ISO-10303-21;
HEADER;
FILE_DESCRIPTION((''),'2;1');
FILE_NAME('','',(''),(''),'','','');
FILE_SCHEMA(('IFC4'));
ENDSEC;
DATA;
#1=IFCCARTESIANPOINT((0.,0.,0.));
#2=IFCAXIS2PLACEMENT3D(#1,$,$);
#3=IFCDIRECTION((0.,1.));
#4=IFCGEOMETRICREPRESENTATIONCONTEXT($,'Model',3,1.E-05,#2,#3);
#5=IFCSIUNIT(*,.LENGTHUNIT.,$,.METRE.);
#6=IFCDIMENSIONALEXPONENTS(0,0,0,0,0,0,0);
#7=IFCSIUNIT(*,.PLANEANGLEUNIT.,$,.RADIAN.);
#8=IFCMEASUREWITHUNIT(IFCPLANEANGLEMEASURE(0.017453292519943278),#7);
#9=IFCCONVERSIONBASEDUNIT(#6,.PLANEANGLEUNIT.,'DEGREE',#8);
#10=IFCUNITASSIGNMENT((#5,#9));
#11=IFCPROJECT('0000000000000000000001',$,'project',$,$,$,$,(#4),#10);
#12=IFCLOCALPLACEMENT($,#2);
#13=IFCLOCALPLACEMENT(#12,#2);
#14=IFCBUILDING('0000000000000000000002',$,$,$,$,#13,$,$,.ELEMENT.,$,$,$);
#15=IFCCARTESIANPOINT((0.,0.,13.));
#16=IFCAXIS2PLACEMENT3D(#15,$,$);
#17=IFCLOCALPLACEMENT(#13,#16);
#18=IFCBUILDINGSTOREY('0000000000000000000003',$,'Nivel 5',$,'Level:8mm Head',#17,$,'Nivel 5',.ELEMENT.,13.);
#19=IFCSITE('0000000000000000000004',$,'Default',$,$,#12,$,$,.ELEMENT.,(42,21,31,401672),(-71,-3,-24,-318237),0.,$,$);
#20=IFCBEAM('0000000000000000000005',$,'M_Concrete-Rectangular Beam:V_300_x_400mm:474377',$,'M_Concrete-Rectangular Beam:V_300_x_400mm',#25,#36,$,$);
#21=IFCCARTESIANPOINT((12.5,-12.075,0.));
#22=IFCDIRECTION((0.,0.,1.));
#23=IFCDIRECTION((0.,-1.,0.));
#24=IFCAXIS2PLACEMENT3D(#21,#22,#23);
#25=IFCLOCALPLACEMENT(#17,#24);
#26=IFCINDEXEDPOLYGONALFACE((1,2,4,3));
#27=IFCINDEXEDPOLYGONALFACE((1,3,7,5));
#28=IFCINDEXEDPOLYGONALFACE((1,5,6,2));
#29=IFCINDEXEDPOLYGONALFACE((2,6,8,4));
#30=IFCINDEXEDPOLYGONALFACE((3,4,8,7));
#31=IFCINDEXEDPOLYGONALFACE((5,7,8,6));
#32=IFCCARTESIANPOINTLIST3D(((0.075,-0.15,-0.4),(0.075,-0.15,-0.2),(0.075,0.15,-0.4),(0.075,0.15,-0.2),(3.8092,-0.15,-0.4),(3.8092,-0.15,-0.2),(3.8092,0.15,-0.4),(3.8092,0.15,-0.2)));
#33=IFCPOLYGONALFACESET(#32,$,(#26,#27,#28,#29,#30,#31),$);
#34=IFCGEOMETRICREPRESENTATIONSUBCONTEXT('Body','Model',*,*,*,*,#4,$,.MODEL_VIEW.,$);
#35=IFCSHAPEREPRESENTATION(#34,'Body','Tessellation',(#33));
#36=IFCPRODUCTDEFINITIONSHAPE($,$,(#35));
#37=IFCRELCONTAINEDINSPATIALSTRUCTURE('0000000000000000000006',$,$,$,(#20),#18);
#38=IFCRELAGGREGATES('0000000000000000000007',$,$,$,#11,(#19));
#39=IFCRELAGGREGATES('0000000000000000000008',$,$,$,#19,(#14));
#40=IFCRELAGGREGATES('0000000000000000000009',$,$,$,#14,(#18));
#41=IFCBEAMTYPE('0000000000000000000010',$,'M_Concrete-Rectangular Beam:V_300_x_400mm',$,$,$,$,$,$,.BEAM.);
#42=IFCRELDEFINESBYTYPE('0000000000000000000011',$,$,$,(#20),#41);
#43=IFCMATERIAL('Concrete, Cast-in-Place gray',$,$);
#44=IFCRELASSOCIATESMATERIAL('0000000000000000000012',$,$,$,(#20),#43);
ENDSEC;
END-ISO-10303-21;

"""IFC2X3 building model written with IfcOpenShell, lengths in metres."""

from ifc_helpers import new_model, entity, si_unit, converted_unit, direction, frame, frame_2d, origin, place, context, subcontext, project, spatial, rectangle, extrude, material, type_object, element, save


model = new_model("IFC2X3")

# Units and contexts
model_context = context("Model", 3, precision=1e-05, world=origin(), true_north=direction((0.0, 1.0)))
body_context = subcontext(model_context, "Body", "Model", "MODEL_VIEW")
ifc_project = project(units=[si_unit("LENGTHUNIT", "METRE"), converted_unit("PLANEANGLEUNIT", "DEGREE", entity("IfcPlaneAngleMeasure", 0.017453292519943278), si_unit("PLANEANGLEUNIT", "RADIAN"), dimensions=[0, 0, 0, 0, 0, 0, 0])], contexts=[model_context])

# Site, building, storey
site_placement = place(None, origin())
site = spatial("IfcSite", under=ifc_project, at=site_placement, Name="Default", CompositionType="ELEMENT", RefLatitude=(42, 21, 31, 401672), RefLongitude=(-71, -3, -24, -318237), RefElevation=0.0)
building_placement = place(site_placement, origin())
building = spatial("IfcBuilding", under=site, at=building_placement, CompositionType="ELEMENT")
storey_placement = place(building_placement, frame((0.0, 0.0, 13.0)))
storey = spatial("IfcBuildingStorey", under=building, at=storey_placement, Name="Nivel 5", ObjectType="Level:8mm Head", LongName="Nivel 5", CompositionType="ELEMENT", Elevation=13.0)

# Beam
ifc_material_1 = material(Name="Concrete, Cast-in-Place gray")
beam_type = type_object("IfcBeamType", Name="M_Concrete-Rectangular Beam:V_300_x_400mm", PredefinedType="BEAM")
beam_placement = place(storey_placement, frame((12.5, -12.075, 0.0), z_axis=(0.0, 0.0, 1.0), x_axis=(0.0, -1.0, 0.0)))
element("IfcBeam", 1, at=beam_placement, inside=storey, type_object=beam_type, material=ifc_material_1, Name="M_Concrete-Rectangular Beam:V_300_x_400mm:474377", ObjectType="M_Concrete-Rectangular Beam:V_300_x_400mm", context=body_context, shape_type="SweptSolid", body=[
    extrude(rectangle(XDim=0.2, YDim=0.3, at=frame_2d((0.0, 0.0), x_axis=(1.0, 0.0))), frame((0.075, 0.0, -0.3), z_axis=(1.0, 0.0, 0.0), x_axis=(0.0, 0.0, -1.0)), (0.0, 0.0, 1.0), 3.7342),
])

save(model, "model.ifc")
